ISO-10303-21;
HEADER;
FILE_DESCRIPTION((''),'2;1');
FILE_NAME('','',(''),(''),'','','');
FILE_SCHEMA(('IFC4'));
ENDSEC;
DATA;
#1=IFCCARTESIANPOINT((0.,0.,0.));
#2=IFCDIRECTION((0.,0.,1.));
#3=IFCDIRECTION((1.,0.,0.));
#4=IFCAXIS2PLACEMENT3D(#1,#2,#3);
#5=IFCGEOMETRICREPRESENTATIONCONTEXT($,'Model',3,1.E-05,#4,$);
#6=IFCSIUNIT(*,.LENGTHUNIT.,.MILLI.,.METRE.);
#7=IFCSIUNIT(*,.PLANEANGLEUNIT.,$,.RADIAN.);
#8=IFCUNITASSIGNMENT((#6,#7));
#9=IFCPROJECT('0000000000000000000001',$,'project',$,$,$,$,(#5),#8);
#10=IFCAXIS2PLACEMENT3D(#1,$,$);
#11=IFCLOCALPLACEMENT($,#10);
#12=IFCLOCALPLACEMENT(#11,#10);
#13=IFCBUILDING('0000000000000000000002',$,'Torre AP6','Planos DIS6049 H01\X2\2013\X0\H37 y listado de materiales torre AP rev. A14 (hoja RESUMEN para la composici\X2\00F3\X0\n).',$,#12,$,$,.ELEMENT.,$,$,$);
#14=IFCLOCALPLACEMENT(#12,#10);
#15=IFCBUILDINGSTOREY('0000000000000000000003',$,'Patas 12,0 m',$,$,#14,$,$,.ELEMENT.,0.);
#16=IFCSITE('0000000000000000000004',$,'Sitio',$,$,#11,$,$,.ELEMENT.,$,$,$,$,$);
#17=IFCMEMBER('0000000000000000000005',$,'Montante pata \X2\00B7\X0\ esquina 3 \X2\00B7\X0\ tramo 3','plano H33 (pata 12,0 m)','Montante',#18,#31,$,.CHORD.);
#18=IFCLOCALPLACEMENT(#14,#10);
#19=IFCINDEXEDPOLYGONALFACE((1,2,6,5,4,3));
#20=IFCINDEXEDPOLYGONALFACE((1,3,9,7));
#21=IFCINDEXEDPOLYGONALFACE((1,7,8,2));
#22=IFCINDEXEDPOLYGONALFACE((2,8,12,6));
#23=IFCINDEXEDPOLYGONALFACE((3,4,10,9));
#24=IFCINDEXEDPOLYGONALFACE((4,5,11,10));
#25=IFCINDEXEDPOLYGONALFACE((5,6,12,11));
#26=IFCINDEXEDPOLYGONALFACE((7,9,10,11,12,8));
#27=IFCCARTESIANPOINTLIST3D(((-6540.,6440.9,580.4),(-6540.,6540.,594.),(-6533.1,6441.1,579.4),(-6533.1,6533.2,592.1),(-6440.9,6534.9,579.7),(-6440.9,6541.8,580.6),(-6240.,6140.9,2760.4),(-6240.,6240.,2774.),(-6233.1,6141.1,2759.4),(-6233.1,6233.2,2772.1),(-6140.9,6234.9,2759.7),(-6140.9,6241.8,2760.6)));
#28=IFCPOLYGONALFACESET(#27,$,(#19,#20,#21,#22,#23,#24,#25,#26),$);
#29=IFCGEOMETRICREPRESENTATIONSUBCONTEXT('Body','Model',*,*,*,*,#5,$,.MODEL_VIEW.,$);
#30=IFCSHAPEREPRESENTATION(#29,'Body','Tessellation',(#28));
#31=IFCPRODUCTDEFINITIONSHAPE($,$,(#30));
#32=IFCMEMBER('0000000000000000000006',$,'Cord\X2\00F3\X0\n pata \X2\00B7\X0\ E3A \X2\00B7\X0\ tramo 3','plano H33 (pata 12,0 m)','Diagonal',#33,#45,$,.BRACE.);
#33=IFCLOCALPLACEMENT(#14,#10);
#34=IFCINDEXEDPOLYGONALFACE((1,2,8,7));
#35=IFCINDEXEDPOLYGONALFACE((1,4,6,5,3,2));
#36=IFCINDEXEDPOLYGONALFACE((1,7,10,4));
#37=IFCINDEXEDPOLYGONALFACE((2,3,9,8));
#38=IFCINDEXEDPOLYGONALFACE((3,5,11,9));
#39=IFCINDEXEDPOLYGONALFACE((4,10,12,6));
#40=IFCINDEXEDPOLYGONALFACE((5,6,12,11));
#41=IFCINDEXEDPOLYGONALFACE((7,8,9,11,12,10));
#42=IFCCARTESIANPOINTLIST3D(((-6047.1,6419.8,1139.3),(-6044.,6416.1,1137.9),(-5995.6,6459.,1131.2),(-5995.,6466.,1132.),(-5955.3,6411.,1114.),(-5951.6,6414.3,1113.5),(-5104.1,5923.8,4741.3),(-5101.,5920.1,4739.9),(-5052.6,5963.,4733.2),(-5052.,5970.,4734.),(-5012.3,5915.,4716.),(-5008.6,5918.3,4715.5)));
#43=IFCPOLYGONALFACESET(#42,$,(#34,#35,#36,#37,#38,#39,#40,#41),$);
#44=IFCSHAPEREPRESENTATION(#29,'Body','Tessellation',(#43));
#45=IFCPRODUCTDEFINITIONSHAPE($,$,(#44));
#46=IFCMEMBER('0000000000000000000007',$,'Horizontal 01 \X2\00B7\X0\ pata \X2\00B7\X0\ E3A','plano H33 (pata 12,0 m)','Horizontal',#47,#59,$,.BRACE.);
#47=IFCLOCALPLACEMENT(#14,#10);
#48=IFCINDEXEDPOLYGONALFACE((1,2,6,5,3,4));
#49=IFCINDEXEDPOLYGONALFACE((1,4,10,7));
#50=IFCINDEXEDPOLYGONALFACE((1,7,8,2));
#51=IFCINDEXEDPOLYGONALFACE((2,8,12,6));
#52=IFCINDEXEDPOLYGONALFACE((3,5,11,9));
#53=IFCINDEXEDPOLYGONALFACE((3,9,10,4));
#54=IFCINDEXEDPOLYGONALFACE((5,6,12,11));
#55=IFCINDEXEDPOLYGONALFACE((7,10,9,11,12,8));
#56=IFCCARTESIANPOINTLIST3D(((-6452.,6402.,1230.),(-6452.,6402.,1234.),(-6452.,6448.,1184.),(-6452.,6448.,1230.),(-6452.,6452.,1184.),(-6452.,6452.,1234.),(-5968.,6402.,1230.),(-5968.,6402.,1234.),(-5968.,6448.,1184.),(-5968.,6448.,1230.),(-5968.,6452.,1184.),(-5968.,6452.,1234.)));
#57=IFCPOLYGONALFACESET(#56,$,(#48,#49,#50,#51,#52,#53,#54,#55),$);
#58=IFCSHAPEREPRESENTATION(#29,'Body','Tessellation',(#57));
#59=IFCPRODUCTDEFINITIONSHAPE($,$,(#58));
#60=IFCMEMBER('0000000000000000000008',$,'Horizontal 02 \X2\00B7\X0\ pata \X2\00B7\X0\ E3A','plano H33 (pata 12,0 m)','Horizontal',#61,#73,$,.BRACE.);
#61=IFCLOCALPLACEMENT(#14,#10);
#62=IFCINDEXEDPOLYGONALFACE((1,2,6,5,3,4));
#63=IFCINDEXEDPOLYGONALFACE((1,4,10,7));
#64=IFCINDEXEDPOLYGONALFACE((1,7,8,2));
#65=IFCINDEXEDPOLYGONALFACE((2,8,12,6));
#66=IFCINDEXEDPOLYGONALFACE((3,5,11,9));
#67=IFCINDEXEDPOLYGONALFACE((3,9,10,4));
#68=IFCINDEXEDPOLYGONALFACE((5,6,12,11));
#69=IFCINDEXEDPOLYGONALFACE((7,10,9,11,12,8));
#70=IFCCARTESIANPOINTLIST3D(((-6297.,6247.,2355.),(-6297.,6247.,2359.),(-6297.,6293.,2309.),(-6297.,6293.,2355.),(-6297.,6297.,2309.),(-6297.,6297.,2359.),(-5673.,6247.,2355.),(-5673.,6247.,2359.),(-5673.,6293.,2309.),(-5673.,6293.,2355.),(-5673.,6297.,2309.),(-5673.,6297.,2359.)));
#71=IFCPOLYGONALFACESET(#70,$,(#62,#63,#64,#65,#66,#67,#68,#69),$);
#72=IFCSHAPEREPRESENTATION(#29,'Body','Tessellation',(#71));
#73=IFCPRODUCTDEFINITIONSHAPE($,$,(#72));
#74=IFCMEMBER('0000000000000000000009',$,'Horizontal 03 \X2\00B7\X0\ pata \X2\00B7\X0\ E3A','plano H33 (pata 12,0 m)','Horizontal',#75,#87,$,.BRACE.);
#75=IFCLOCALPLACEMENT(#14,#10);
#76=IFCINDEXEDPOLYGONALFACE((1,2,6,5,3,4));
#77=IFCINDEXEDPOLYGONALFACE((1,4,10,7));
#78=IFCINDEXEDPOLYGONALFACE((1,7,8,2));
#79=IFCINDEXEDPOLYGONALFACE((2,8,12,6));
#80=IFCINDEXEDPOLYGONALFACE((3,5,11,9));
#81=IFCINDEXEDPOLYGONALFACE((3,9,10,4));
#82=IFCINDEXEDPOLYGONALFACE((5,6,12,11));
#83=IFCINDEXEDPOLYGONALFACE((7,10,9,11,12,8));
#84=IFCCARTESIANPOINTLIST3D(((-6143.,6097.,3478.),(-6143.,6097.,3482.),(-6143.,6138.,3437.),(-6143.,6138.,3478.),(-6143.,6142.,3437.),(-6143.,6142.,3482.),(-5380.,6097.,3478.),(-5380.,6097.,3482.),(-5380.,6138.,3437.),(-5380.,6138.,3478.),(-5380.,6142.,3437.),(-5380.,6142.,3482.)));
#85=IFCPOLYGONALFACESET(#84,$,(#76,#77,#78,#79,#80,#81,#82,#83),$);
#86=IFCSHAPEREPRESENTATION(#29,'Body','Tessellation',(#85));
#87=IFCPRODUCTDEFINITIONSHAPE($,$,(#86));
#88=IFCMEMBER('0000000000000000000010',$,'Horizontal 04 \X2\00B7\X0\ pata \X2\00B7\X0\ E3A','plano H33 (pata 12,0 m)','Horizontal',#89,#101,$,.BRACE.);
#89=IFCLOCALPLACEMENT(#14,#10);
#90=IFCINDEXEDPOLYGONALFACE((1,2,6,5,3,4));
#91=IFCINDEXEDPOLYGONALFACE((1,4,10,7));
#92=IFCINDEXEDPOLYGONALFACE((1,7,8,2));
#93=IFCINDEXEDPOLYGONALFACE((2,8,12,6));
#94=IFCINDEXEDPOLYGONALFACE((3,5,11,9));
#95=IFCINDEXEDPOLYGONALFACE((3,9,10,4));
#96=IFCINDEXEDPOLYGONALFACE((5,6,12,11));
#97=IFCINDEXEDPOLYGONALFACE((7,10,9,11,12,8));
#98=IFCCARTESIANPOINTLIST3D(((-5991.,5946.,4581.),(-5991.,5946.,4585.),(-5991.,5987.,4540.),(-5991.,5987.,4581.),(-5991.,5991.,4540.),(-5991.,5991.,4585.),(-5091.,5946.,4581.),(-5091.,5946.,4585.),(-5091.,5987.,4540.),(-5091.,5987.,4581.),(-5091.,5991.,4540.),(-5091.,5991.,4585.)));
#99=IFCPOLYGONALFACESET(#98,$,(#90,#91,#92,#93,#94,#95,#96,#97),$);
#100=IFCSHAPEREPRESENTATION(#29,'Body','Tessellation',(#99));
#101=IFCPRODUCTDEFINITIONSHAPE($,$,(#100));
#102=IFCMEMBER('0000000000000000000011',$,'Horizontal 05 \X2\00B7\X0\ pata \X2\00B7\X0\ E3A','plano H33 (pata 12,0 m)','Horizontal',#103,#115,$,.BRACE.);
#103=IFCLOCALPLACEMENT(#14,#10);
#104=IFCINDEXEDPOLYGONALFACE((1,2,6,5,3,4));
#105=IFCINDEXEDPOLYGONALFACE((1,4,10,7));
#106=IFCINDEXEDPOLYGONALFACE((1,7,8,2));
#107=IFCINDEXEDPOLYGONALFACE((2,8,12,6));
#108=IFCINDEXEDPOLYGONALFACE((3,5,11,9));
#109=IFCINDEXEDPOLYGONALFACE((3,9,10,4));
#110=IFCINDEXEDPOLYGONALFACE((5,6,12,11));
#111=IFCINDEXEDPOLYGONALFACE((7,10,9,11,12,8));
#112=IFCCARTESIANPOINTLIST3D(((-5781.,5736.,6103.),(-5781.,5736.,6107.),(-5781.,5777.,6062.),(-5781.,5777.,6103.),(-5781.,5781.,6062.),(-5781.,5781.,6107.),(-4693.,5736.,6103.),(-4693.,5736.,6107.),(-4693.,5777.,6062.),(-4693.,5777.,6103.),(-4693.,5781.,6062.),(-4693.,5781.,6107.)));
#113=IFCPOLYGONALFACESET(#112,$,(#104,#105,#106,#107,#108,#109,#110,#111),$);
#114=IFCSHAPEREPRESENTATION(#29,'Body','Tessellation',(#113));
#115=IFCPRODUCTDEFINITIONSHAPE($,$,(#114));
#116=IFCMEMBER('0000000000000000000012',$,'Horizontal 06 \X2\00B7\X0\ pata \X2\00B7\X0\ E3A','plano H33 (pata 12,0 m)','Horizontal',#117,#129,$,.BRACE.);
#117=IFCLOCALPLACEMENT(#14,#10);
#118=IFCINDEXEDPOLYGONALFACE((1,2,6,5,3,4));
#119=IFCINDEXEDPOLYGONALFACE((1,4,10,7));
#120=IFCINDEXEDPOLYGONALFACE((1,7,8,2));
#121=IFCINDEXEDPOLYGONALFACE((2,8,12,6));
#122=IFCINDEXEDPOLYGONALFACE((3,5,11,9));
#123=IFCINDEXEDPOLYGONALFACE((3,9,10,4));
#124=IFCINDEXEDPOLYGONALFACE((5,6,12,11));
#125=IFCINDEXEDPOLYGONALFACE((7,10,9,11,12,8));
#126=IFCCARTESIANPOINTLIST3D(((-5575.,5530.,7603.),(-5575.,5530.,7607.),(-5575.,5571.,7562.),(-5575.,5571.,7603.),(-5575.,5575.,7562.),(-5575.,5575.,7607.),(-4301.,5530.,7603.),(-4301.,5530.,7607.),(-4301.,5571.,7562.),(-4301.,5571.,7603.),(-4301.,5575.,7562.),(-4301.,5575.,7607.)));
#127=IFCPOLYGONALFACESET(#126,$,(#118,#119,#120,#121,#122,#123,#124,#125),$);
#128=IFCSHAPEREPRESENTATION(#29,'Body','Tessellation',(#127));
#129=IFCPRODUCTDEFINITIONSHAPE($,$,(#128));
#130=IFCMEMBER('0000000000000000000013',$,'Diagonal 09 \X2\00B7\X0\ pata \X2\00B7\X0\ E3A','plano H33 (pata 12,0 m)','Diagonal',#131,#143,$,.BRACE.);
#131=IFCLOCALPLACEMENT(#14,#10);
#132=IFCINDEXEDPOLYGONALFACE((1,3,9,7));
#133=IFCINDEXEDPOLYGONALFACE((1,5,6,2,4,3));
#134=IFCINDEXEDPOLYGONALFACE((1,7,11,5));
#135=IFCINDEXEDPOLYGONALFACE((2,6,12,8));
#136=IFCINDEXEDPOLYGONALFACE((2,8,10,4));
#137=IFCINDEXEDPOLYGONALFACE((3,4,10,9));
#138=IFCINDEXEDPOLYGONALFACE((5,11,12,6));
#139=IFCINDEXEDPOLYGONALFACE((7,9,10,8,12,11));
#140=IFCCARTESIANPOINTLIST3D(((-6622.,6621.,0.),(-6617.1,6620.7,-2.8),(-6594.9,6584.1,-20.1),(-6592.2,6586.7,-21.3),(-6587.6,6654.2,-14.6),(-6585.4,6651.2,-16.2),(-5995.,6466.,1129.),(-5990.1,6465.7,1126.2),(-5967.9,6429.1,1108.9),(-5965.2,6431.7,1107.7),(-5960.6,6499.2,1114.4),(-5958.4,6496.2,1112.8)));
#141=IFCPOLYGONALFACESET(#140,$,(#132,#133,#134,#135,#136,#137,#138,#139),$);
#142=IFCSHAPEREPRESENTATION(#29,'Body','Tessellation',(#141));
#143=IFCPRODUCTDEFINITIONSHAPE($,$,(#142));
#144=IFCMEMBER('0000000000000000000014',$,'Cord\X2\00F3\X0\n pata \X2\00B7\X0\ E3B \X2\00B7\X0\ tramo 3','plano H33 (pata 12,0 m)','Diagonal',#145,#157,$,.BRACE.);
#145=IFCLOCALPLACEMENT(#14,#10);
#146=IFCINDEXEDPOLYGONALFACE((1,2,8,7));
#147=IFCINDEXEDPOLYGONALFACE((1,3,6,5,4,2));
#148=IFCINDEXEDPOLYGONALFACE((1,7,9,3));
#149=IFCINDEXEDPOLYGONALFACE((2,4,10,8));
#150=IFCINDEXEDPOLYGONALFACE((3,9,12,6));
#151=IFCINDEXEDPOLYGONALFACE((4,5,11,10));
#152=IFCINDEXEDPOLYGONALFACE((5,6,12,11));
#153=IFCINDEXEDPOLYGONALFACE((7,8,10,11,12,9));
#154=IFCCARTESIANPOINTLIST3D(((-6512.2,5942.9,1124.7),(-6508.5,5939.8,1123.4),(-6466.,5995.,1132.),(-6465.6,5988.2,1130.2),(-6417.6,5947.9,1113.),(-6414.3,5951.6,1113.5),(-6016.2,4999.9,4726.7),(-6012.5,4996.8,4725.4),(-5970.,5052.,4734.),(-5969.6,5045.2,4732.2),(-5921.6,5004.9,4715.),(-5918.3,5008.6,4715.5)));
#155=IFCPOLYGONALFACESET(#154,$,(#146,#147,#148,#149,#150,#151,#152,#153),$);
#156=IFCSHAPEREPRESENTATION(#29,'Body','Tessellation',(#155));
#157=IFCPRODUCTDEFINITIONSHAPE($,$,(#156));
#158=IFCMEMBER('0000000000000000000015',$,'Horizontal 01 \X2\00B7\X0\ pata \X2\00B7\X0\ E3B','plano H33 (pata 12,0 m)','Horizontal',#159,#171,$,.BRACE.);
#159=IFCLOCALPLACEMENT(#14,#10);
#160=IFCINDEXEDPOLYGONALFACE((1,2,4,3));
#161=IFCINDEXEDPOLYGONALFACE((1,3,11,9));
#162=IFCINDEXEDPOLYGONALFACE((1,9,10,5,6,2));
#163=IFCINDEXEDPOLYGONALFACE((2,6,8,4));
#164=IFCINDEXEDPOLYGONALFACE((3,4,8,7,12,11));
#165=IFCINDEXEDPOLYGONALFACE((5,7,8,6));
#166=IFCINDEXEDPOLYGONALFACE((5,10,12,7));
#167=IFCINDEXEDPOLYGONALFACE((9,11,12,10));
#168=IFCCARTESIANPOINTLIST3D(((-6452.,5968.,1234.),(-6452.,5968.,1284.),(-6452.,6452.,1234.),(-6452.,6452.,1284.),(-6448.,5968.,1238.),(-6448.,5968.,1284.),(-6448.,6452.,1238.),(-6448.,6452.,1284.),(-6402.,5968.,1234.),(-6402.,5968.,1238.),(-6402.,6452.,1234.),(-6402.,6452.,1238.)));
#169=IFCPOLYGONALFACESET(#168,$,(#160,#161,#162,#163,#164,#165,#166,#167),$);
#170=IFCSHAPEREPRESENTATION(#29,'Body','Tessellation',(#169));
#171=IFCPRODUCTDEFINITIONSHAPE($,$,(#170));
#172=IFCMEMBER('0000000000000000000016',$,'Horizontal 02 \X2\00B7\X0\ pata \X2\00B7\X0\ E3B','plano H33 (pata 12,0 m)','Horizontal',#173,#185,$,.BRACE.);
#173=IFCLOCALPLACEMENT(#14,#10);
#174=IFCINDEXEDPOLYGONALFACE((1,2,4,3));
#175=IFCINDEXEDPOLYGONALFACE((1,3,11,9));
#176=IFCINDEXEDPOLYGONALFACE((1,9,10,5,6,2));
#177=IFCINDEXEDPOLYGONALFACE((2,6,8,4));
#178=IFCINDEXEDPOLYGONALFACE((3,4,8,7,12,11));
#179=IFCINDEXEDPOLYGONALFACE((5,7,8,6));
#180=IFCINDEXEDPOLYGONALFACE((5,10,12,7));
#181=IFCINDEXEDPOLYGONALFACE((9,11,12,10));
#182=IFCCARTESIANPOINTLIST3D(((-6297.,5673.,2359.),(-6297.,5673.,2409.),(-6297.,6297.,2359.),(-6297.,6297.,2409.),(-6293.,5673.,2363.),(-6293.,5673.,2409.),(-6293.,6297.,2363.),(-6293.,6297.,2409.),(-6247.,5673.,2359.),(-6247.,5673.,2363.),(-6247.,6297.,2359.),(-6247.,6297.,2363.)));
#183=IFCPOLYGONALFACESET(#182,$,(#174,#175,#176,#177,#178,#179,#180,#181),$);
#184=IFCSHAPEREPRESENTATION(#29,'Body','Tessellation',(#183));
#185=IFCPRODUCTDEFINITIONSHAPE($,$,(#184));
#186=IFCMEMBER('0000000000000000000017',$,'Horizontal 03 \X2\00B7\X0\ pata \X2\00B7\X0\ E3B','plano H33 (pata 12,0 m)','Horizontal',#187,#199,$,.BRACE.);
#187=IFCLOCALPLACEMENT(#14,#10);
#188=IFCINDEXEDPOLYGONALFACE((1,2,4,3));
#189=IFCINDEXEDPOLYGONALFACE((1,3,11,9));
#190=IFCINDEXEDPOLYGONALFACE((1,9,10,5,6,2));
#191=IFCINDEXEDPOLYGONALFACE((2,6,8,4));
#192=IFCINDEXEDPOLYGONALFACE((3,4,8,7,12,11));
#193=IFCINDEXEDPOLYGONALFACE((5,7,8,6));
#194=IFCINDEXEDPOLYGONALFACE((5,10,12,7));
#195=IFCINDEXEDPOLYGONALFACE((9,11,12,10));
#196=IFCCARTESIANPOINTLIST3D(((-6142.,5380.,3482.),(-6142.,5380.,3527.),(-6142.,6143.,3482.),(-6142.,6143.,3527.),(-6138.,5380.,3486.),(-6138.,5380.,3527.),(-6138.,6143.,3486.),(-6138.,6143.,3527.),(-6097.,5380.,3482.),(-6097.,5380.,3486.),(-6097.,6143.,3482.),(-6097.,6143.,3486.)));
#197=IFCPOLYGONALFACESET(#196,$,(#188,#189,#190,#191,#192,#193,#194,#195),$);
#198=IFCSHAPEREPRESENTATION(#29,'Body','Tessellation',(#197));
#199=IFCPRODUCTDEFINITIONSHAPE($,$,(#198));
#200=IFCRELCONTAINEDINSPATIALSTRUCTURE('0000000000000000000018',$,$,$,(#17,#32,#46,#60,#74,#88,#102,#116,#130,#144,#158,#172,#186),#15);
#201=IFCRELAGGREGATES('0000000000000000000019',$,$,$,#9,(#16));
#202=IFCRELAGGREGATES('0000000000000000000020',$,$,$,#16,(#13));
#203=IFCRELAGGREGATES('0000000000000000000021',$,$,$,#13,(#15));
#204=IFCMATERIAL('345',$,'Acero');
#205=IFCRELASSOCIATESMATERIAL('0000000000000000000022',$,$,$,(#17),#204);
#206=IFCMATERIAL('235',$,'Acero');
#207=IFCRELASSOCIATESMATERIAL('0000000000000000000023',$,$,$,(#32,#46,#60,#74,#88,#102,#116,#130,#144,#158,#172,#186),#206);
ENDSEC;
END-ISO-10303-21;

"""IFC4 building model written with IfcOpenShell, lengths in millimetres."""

from ifc_helpers import new_model, si_unit, frame, frame_2d, origin, origin_with_axes, place, context, subcontext, project, spatial, l_section, extrude, material, element, save


model = new_model("IFC4")

# Units and contexts
model_context = context("Model", 3, precision=1e-05, world=origin_with_axes())
body_context = subcontext(model_context, "Body", "Model", "MODEL_VIEW")
ifc_project = project(units=[si_unit("LENGTHUNIT", "METRE", prefix="MILLI"), si_unit("PLANEANGLEUNIT", "RADIAN")], contexts=[model_context])

# Site, building, storey
site_placement = place(None, origin())
site = spatial("IfcSite", under=ifc_project, at=site_placement, Name="Sitio", CompositionType="ELEMENT")
building_placement = place(site_placement, origin())
building = spatial("IfcBuilding", under=site, at=building_placement, Name="Torre AP6", Description="Planos DIS6049 H01–H37 y listado de materiales torre AP rev. A14 (hoja RESUMEN para la composición).", CompositionType="ELEMENT")
storey_placement = place(building_placement, origin())
storey = spatial("IfcBuildingStorey", under=building, at=storey_placement, Name="Patas 12,0 m", CompositionType="ELEMENT", Elevation=0.0)

# Members
ifc_material_1 = material(Name="345", Category="Acero")
member_1_placement = place(storey_placement, frame((-6240.0, 6240.0, 2774.0), z_axis=(-0.13508, 0.13508, -0.981584), x_axis=(0.990835, 0.018415, -0.133819)))
element("IfcMember", 1, at=member_1_placement, inside=storey, material=ifc_material_1, Name="Montante pata · esquina 3 · tramo 3", Description="plano H33 (pata 12,0 m)", ObjectType="Montante", PredefinedType="CHORD", context=body_context, shape_type="SweptSolid", body=[
    extrude(l_section(Depth=100.0, Width=100.0, Thickness=7.0, at=frame_2d((50.0, 50.0))), None, (0.0, 0.0, 1.0), 2220.9),
])
ifc_material_2 = material(Name="235", Category="Acero")
member_2_placement = place(storey_placement, frame((-5052.0, 5970.0, 4734.0), z_axis=(-0.251046, 0.132045, -0.958926), x_axis=(0.619714, -0.739088, -0.264014)))
element("IfcMember", 2, at=member_2_placement, inside=storey, material=ifc_material_2, Name="Cordón pata · E3A · tramo 3", Description="plano H33 (pata 12,0 m)", ObjectType="Diagonal", PredefinedType="BRACE", context=body_context, shape_type="SweptSolid", body=[
    extrude(l_section(Depth=70.0, Width=70.0, Thickness=5.0, at=frame_2d((35.0, 35.0))), None, (0.0, 0.0, 1.0), 3756.3),
])
member_3_placement = place(storey_placement, frame((-6452.0, 6452.0, 1234.0), z_axis=(1.0, 0.0, 0.0), x_axis=(0.0, -1.0, 0.0)))
element("IfcMember", 3, at=member_3_placement, inside=storey, material=ifc_material_2, Name="Horizontal 01 · pata · E3A", Description="plano H33 (pata 12,0 m)", ObjectType="Horizontal", PredefinedType="BRACE", context=body_context, shape_type="SweptSolid", body=[
    extrude(l_section(Depth=50.0, Width=50.0, Thickness=4.0, at=frame_2d((25.0, 25.0))), None, (0.0, 0.0, 1.0), 484.0),
])
member_4_placement = place(storey_placement, frame((-6297.0, 6297.0, 2359.0), z_axis=(1.0, 0.0, 0.0), x_axis=(0.0, -1.0, 0.0)))
element("IfcMember", 4, at=member_4_placement, inside=storey, material=ifc_material_2, Name="Horizontal 02 · pata · E3A", Description="plano H33 (pata 12,0 m)", ObjectType="Horizontal", PredefinedType="BRACE", context=body_context, shape_type="SweptSolid", body=[
    extrude(l_section(Depth=50.0, Width=50.0, Thickness=4.0, at=frame_2d((25.0, 25.0))), None, (0.0, 0.0, 1.0), 624.0),
])
member_5_placement = place(storey_placement, frame((-6143.0, 6142.0, 3482.0), z_axis=(1.0, 0.0, 0.0), x_axis=(0.0, -1.0, 0.0)))
element("IfcMember", 5, at=member_5_placement, inside=storey, material=ifc_material_2, Name="Horizontal 03 · pata · E3A", Description="plano H33 (pata 12,0 m)", ObjectType="Horizontal", PredefinedType="BRACE", context=body_context, shape_type="SweptSolid", body=[
    extrude(l_section(Depth=45.0, Width=45.0, Thickness=4.0, at=frame_2d((22.5, 22.5))), None, (0.0, 0.0, 1.0), 763.0),
])
member_6_placement = place(storey_placement, frame((-5991.0, 5991.0, 4585.0), z_axis=(1.0, 0.0, 0.0), x_axis=(0.0, -1.0, 0.0)))
element("IfcMember", 6, at=member_6_placement, inside=storey, material=ifc_material_2, Name="Horizontal 04 · pata · E3A", Description="plano H33 (pata 12,0 m)", ObjectType="Horizontal", PredefinedType="BRACE", context=body_context, shape_type="SweptSolid", body=[
    extrude(l_section(Depth=45.0, Width=45.0, Thickness=4.0, at=frame_2d((22.5, 22.5))), None, (0.0, 0.0, 1.0), 900.0),
])
member_7_placement = place(storey_placement, frame((-5781.0, 5781.0, 6107.0), z_axis=(1.0, 0.0, 0.0), x_axis=(0.0, -1.0, 0.0)))
element("IfcMember", 7, at=member_7_placement, inside=storey, material=ifc_material_2, Name="Horizontal 05 · pata · E3A", Description="plano H33 (pata 12,0 m)", ObjectType="Horizontal", PredefinedType="BRACE", context=body_context, shape_type="SweptSolid", body=[
    extrude(l_section(Depth=45.0, Width=45.0, Thickness=4.0, at=frame_2d((22.5, 22.5))), None, (0.0, 0.0, 1.0), 1088.0),
])
member_8_placement = place(storey_placement, frame((-5575.0, 5575.0, 7607.0), z_axis=(1.0, 0.0, 0.0), x_axis=(0.0, -1.0, 0.0)))
element("IfcMember", 8, at=member_8_placement, inside=storey, material=ifc_material_2, Name="Horizontal 06 · pata · E3A", Description="plano H33 (pata 12,0 m)", ObjectType="Horizontal", PredefinedType="BRACE", context=body_context, shape_type="SweptSolid", body=[
    extrude(l_section(Depth=45.0, Width=45.0, Thickness=4.0, at=frame_2d((22.5, 22.5))), None, (0.0, 0.0, 1.0), 1274.0),
])
member_9_placement = place(storey_placement, frame((-6622.0, 6621.0, 0.0), z_axis=(0.482052, -0.119168, 0.868001), x_axis=(0.5416, -0.738214, -0.402132)))
element("IfcMember", 9, at=member_9_placement, inside=storey, material=ifc_material_2, Name="Diagonal 09 · pata · E3A", Description="plano H33 (pata 12,0 m)", ObjectType="Diagonal", PredefinedType="BRACE", context=body_context, shape_type="SweptSolid", body=[
    extrude(l_section(Depth=50.0, Width=50.0, Thickness=4.0, at=frame_2d((25.0, 25.0))), None, (0.0, 0.0, 1.0), 1300.7),
])
member_10_placement = place(storey_placement, frame((-5970.0, 5052.0, 4734.0), z_axis=(-0.132045, 0.251046, -0.958926), x_axis=(0.739088, -0.619714, -0.264014)))
element("IfcMember", 10, at=member_10_placement, inside=storey, material=ifc_material_2, Name="Cordón pata · E3B · tramo 3", Description="plano H33 (pata 12,0 m)", ObjectType="Diagonal", PredefinedType="BRACE", context=body_context, shape_type="SweptSolid", body=[
    extrude(l_section(Depth=70.0, Width=70.0, Thickness=5.0, at=frame_2d((35.0, 35.0))), None, (0.0, 0.0, 1.0), 3756.3),
])
member_11_placement = place(storey_placement, frame((-6452.0, 6452.0, 1234.0), z_axis=(0.0, -1.0, 0.0), x_axis=(1.0, 0.0, 0.0)))
element("IfcMember", 11, at=member_11_placement, inside=storey, material=ifc_material_2, Name="Horizontal 01 · pata · E3B", Description="plano H33 (pata 12,0 m)", ObjectType="Horizontal", PredefinedType="BRACE", context=body_context, shape_type="SweptSolid", body=[
    extrude(l_section(Depth=50.0, Width=50.0, Thickness=4.0, at=frame_2d((25.0, 25.0))), None, (0.0, 0.0, 1.0), 484.0),
])
member_12_placement = place(storey_placement, frame((-6297.0, 6297.0, 2359.0), z_axis=(0.0, -1.0, 0.0), x_axis=(1.0, 0.0, 0.0)))
element("IfcMember", 12, at=member_12_placement, inside=storey, material=ifc_material_2, Name="Horizontal 02 · pata · E3B", Description="plano H33 (pata 12,0 m)", ObjectType="Horizontal", PredefinedType="BRACE", context=body_context, shape_type="SweptSolid", body=[
    extrude(l_section(Depth=50.0, Width=50.0, Thickness=4.0, at=frame_2d((25.0, 25.0))), None, (0.0, 0.0, 1.0), 624.0),
])
member_13_placement = place(storey_placement, frame((-6142.0, 6143.0, 3482.0), z_axis=(0.0, -1.0, 0.0), x_axis=(1.0, 0.0, 0.0)))
element("IfcMember", 13, at=member_13_placement, inside=storey, material=ifc_material_2, Name="Horizontal 03 · pata · E3B", Description="plano H33 (pata 12,0 m)", ObjectType="Horizontal", PredefinedType="BRACE", context=body_context, shape_type="SweptSolid", body=[
    extrude(l_section(Depth=45.0, Width=45.0, Thickness=4.0, at=frame_2d((22.5, 22.5))), None, (0.0, 0.0, 1.0), 763.0),
])

save(model, "model.ifc")
